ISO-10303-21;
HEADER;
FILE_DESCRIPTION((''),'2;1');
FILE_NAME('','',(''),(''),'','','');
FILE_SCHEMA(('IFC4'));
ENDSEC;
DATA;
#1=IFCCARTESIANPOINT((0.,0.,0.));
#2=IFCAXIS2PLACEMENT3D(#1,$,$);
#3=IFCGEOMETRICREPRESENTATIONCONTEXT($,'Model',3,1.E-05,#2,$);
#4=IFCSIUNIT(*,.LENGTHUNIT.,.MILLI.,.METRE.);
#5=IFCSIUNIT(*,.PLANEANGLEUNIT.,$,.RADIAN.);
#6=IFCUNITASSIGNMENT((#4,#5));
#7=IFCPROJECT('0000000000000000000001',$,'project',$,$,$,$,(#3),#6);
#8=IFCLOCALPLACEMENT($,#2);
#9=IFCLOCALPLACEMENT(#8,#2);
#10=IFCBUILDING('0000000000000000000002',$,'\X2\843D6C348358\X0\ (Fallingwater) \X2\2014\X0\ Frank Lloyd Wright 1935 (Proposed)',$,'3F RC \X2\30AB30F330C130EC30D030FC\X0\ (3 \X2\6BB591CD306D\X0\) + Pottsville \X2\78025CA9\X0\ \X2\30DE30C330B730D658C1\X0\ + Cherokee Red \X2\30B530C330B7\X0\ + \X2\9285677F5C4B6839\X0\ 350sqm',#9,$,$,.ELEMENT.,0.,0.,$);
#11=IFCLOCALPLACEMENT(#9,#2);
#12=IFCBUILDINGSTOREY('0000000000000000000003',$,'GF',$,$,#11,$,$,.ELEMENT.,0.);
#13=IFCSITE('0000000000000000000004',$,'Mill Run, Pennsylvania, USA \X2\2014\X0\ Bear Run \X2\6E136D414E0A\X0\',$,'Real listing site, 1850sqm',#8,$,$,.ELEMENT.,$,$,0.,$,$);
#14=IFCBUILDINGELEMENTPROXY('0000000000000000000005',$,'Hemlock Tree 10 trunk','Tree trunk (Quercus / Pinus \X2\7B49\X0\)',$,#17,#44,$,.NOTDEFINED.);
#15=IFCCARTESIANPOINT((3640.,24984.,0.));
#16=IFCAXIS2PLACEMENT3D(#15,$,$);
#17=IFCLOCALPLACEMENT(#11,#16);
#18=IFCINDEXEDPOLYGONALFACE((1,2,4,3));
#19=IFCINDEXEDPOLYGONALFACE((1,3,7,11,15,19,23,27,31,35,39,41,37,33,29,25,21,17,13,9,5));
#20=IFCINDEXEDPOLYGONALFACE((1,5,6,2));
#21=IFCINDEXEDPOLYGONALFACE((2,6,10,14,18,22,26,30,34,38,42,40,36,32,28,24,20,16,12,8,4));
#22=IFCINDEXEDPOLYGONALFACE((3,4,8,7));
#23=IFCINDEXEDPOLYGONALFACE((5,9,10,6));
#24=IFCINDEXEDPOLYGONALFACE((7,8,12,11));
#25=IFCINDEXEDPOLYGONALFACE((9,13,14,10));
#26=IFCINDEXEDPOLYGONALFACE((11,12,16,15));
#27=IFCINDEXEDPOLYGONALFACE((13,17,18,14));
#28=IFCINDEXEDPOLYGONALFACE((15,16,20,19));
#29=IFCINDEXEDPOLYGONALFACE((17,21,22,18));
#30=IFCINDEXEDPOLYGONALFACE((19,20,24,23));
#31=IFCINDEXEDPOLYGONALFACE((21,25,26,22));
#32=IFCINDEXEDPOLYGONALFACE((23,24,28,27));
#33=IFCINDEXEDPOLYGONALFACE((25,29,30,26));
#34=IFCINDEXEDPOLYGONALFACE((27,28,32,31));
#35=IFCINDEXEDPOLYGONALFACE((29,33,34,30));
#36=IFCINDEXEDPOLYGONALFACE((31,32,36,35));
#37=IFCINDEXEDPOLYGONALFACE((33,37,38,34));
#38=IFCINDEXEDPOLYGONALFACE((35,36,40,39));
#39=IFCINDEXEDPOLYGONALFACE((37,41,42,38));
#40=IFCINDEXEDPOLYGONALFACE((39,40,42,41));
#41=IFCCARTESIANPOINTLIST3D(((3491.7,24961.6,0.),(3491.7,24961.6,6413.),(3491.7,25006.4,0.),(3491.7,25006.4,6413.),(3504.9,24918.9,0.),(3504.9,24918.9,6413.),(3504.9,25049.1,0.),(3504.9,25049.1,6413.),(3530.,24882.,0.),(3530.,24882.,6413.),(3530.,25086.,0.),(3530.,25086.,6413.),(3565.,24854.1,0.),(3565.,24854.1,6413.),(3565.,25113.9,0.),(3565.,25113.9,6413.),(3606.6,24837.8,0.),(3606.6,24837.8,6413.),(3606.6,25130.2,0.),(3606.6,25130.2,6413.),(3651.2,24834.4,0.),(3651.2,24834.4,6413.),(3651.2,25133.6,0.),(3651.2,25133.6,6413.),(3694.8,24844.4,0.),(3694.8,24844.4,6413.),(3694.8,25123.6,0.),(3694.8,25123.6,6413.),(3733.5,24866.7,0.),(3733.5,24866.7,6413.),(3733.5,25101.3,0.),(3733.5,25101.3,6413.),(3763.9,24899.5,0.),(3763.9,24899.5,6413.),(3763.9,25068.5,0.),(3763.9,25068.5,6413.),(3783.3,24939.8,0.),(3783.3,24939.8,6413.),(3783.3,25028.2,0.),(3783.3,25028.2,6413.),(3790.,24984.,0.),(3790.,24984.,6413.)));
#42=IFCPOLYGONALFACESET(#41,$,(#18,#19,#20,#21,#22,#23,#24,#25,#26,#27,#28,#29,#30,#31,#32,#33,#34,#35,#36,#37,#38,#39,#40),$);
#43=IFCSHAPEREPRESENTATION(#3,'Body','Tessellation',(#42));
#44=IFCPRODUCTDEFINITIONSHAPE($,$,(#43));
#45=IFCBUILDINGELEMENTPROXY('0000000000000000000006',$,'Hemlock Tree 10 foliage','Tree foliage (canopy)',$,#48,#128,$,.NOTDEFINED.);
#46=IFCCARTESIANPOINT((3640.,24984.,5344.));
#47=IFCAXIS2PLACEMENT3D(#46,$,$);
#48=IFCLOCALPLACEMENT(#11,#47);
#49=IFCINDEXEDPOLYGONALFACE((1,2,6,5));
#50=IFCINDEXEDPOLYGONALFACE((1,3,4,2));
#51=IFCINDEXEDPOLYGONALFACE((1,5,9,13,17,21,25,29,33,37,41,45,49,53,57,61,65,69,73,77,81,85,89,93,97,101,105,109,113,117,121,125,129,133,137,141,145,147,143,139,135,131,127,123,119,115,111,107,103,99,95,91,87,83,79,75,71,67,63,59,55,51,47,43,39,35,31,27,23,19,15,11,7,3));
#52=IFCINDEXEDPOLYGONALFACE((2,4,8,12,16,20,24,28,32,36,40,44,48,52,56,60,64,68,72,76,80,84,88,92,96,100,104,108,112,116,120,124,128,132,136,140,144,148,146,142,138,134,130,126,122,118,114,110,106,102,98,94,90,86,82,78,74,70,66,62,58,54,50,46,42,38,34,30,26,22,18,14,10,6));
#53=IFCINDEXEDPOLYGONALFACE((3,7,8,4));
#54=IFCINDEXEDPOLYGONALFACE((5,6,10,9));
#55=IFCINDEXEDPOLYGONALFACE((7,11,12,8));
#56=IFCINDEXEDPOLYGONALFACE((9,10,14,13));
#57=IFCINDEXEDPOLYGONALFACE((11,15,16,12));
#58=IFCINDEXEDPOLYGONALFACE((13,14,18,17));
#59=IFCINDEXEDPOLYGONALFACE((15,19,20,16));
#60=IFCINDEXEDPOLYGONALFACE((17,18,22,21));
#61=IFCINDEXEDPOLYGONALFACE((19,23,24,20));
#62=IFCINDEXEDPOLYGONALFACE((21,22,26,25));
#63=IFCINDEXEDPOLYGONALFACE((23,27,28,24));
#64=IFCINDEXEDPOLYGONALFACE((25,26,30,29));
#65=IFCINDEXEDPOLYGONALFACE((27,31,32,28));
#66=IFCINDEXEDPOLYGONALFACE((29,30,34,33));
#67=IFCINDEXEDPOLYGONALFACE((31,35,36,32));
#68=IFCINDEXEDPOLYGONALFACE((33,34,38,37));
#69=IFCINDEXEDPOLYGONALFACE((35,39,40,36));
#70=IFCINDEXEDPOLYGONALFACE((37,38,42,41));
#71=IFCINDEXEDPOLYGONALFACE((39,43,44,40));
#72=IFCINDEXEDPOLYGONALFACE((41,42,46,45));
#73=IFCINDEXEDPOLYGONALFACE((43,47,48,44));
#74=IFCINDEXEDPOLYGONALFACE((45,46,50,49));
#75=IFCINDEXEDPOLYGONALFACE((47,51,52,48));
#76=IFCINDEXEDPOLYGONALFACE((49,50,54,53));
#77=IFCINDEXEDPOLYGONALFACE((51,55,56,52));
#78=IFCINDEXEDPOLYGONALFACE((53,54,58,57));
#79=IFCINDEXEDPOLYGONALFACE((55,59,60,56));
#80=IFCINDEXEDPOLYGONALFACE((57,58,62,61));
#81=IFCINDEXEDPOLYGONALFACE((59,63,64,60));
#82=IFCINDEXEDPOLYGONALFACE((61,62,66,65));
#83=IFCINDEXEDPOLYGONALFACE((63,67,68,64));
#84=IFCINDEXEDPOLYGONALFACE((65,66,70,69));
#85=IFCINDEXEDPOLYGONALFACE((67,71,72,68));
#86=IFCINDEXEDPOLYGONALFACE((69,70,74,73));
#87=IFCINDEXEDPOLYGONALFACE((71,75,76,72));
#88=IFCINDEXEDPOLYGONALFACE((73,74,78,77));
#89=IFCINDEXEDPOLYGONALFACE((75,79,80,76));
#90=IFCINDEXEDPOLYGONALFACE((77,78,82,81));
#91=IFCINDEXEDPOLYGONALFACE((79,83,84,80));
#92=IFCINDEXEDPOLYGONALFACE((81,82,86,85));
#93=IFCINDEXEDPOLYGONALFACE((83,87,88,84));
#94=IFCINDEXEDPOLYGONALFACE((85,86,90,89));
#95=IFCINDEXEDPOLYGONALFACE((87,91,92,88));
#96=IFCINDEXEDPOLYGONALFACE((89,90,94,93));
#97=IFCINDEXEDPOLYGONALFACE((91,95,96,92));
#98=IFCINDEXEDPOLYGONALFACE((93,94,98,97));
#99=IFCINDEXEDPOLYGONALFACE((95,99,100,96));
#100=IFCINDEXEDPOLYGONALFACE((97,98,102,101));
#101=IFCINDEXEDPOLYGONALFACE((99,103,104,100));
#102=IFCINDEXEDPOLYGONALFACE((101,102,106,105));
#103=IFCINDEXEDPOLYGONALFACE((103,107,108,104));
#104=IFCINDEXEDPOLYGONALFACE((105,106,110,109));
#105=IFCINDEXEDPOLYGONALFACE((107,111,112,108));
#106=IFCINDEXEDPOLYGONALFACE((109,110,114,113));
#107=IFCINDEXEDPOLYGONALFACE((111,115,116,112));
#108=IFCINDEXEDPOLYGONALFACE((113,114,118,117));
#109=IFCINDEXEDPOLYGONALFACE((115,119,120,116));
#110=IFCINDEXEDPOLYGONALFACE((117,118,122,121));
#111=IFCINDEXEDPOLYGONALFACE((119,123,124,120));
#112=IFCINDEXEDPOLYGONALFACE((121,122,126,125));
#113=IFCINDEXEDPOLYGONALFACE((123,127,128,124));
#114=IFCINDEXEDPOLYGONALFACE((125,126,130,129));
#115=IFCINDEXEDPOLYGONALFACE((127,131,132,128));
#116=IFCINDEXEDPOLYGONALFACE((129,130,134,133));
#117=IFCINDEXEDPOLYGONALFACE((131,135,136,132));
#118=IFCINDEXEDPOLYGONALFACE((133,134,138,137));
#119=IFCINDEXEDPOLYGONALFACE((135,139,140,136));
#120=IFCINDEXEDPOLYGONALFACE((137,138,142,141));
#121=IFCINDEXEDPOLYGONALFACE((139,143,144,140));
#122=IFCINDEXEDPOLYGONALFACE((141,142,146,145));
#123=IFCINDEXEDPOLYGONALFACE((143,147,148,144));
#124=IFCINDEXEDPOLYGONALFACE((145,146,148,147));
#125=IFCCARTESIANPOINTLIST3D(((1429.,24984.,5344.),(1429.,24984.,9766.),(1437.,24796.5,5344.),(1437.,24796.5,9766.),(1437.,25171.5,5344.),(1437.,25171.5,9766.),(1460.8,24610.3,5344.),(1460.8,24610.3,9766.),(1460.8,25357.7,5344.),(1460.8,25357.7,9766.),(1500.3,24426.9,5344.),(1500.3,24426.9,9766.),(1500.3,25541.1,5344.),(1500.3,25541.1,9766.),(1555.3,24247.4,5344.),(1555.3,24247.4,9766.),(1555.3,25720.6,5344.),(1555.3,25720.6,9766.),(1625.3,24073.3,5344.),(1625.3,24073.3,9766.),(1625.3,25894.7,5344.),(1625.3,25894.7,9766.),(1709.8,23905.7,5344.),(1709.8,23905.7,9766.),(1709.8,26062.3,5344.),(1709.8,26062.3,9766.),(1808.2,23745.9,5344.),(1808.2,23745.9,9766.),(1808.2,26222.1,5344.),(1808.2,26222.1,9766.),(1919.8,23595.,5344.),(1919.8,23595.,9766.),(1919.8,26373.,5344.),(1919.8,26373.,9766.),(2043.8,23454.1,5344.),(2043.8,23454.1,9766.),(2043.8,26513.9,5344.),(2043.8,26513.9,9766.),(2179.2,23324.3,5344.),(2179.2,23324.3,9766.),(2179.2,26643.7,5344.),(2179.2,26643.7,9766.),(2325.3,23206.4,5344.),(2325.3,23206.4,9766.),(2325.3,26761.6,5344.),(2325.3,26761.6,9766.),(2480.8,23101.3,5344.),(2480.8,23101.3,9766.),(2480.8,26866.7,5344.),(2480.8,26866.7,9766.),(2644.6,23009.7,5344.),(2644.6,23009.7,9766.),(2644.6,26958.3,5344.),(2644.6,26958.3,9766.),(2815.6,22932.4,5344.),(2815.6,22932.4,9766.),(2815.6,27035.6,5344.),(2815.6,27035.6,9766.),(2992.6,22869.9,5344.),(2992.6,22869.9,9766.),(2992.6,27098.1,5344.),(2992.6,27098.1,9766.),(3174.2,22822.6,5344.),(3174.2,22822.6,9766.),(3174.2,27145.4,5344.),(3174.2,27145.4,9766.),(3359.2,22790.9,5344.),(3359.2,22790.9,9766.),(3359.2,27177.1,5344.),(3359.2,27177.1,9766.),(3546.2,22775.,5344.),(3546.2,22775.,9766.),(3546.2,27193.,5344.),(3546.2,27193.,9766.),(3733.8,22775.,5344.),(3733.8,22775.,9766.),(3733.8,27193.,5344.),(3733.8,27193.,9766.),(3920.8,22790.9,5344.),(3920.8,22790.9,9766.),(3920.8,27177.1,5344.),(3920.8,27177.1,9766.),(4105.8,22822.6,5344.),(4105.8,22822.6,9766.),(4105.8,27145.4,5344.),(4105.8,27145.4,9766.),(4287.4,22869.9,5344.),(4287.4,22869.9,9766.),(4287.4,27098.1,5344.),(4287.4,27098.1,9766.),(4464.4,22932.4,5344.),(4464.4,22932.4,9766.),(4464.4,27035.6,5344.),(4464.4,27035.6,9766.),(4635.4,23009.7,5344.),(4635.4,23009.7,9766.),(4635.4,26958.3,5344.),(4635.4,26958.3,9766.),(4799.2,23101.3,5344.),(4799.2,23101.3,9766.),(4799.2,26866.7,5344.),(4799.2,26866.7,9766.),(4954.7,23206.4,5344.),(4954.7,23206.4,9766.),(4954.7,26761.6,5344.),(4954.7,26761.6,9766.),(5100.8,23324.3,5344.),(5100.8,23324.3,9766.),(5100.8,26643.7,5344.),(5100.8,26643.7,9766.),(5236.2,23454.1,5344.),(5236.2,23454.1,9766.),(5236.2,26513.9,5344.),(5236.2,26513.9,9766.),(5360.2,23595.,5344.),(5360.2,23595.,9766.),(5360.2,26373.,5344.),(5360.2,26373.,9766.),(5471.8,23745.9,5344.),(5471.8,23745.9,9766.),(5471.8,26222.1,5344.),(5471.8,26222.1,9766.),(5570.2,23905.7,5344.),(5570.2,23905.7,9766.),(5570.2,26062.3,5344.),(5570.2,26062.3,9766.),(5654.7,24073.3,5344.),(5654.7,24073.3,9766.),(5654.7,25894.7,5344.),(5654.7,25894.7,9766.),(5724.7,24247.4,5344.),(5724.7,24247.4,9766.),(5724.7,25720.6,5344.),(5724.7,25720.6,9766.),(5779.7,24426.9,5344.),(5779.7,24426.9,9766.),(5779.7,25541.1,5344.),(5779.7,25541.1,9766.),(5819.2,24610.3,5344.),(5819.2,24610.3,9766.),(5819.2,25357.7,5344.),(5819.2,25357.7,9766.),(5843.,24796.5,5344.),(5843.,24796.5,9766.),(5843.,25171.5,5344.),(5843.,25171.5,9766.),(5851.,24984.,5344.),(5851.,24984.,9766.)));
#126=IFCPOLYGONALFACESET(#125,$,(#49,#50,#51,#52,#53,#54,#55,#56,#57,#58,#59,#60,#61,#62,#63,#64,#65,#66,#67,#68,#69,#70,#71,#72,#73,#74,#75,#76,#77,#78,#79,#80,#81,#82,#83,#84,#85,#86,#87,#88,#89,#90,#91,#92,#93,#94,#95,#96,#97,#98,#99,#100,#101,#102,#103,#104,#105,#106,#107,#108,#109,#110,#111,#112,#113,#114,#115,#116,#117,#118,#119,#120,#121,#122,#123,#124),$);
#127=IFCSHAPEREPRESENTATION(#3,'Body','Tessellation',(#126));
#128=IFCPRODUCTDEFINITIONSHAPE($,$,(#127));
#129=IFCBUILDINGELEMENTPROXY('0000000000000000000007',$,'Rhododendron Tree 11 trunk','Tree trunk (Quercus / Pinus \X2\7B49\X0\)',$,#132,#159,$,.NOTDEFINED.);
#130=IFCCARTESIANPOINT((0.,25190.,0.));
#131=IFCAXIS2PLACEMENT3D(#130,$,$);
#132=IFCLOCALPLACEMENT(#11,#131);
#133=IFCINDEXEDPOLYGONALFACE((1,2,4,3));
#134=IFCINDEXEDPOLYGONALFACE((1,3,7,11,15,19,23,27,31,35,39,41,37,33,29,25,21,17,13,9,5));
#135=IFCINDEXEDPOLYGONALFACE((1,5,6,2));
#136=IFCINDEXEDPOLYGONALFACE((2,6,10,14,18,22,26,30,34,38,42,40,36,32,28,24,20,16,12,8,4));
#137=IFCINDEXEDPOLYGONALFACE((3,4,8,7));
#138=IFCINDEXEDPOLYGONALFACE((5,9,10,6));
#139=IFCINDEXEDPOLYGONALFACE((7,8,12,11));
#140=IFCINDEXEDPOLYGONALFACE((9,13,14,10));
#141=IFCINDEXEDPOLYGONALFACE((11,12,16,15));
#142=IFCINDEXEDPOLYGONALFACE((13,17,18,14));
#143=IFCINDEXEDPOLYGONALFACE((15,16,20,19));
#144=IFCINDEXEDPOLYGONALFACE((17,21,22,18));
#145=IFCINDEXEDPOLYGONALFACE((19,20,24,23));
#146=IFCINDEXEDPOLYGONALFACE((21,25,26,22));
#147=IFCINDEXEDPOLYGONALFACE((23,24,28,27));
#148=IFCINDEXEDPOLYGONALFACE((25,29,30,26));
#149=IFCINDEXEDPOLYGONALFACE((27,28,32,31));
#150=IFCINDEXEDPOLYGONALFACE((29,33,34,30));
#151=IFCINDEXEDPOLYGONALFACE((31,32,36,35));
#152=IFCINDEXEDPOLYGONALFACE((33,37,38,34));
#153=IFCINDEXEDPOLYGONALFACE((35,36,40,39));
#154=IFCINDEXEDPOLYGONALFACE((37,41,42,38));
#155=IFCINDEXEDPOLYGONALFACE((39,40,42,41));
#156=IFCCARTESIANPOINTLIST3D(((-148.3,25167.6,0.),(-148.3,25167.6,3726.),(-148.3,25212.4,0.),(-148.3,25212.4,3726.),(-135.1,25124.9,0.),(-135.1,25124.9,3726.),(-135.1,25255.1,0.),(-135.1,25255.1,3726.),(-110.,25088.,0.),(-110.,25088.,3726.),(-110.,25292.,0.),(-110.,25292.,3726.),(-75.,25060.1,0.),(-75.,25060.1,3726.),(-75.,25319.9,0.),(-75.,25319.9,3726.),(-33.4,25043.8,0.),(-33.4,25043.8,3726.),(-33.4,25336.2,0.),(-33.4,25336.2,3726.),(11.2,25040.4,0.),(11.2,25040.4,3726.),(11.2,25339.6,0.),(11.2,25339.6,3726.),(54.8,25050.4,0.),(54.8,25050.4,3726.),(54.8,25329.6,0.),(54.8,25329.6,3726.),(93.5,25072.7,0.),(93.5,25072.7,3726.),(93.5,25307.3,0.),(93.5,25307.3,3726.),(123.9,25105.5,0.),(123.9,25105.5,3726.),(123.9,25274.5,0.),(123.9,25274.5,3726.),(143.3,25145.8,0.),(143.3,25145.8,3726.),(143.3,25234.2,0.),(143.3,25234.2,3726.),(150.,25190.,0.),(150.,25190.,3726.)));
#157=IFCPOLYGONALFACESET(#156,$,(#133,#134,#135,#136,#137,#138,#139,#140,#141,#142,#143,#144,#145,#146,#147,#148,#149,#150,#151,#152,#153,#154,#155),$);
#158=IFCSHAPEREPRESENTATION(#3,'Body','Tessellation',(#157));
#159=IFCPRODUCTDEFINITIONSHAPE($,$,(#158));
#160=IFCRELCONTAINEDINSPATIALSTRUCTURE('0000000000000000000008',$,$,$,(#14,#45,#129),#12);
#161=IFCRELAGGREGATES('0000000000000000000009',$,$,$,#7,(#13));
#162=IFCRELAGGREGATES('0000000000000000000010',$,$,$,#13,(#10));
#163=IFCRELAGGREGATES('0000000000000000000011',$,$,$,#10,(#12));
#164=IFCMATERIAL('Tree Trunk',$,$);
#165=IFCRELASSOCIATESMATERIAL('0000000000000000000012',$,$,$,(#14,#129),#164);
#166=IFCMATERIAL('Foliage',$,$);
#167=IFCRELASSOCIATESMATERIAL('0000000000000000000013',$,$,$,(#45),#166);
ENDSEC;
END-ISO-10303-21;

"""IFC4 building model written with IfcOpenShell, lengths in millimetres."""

from ifc_helpers import new_model, si_unit, frame, origin, origin_2d, place, context, project, spatial, circle, extrude, material, element, save


model = new_model("IFC4")

# Units and contexts
model_context = context("Model", 3, precision=1e-05, world=origin())
ifc_project = project(units=[si_unit("LENGTHUNIT", "METRE", prefix="MILLI"), si_unit("PLANEANGLEUNIT", "RADIAN")], contexts=[model_context])

# Site, building, storey
site_placement = place(None, origin())
site = spatial("IfcSite", under=ifc_project, at=site_placement, Name="Mill Run, Pennsylvania, USA — Bear Run 渓流上", ObjectType="Real listing site, 1850sqm", CompositionType="ELEMENT", RefElevation=0.0)
building_placement = place(site_placement, origin())
building = spatial("IfcBuilding", under=site, at=building_placement, Name="落水荘 (Fallingwater) — Frank Lloyd Wright 1935 (Proposed)", ObjectType="3F RC カンチレバー (3 段重ね) + Pottsville 砂岩 マッシブ壁 + Cherokee Red サッシ + 銅板屋根 350sqm", CompositionType="ELEMENT", ElevationOfRefHeight=0.0, ElevationOfTerrain=0.0)
storey_placement = place(building_placement, origin())
storey = spatial("IfcBuildingStorey", under=building, at=storey_placement, Name="GF", CompositionType="ELEMENT", Elevation=0.0)

# Building element proxies
ifc_material_1 = material(Name="Tree Trunk")
ifc_material_2 = material(Name="Foliage")
proxy_1_placement = place(storey_placement, frame((3640.0, 24984.0, 0.0)))
element("IfcBuildingElementProxy", 1, at=proxy_1_placement, inside=storey, material=ifc_material_1, Name="Hemlock Tree 10 trunk", Description="Tree trunk (Quercus / Pinus 等)", PredefinedType="NOTDEFINED", context=model_context, shape_type="SweptSolid", body=[
    extrude(circle(Radius=150.0, at=origin_2d()), frame((3640.0, 24984.0, 0.0)), (0.0, 0.0, 1.0), 6413.0),
])
proxy_2_placement = place(storey_placement, frame((3640.0, 24984.0, 5344.0)))
element("IfcBuildingElementProxy", 2, at=proxy_2_placement, inside=storey, material=ifc_material_2, Name="Hemlock Tree 10 foliage", Description="Tree foliage (canopy)", PredefinedType="NOTDEFINED", context=model_context, shape_type="SweptSolid", body=[
    extrude(circle(Radius=2211.0, at=origin_2d()), frame((3640.0, 24984.0, 5344.0)), (0.0, 0.0, 1.0), 4422.0),
])
proxy_3_placement = place(storey_placement, frame((0.0, 25190.0, 0.0)))
element("IfcBuildingElementProxy", 3, at=proxy_3_placement, inside=storey, material=ifc_material_1, Name="Rhododendron Tree 11 trunk", Description="Tree trunk (Quercus / Pinus 等)", PredefinedType="NOTDEFINED", context=model_context, shape_type="SweptSolid", body=[
    extrude(circle(Radius=150.0, at=origin_2d()), frame((0.0, 25190.0, 0.0)), (0.0, 0.0, 1.0), 3726.0),
])

save(model, "model.ifc")
